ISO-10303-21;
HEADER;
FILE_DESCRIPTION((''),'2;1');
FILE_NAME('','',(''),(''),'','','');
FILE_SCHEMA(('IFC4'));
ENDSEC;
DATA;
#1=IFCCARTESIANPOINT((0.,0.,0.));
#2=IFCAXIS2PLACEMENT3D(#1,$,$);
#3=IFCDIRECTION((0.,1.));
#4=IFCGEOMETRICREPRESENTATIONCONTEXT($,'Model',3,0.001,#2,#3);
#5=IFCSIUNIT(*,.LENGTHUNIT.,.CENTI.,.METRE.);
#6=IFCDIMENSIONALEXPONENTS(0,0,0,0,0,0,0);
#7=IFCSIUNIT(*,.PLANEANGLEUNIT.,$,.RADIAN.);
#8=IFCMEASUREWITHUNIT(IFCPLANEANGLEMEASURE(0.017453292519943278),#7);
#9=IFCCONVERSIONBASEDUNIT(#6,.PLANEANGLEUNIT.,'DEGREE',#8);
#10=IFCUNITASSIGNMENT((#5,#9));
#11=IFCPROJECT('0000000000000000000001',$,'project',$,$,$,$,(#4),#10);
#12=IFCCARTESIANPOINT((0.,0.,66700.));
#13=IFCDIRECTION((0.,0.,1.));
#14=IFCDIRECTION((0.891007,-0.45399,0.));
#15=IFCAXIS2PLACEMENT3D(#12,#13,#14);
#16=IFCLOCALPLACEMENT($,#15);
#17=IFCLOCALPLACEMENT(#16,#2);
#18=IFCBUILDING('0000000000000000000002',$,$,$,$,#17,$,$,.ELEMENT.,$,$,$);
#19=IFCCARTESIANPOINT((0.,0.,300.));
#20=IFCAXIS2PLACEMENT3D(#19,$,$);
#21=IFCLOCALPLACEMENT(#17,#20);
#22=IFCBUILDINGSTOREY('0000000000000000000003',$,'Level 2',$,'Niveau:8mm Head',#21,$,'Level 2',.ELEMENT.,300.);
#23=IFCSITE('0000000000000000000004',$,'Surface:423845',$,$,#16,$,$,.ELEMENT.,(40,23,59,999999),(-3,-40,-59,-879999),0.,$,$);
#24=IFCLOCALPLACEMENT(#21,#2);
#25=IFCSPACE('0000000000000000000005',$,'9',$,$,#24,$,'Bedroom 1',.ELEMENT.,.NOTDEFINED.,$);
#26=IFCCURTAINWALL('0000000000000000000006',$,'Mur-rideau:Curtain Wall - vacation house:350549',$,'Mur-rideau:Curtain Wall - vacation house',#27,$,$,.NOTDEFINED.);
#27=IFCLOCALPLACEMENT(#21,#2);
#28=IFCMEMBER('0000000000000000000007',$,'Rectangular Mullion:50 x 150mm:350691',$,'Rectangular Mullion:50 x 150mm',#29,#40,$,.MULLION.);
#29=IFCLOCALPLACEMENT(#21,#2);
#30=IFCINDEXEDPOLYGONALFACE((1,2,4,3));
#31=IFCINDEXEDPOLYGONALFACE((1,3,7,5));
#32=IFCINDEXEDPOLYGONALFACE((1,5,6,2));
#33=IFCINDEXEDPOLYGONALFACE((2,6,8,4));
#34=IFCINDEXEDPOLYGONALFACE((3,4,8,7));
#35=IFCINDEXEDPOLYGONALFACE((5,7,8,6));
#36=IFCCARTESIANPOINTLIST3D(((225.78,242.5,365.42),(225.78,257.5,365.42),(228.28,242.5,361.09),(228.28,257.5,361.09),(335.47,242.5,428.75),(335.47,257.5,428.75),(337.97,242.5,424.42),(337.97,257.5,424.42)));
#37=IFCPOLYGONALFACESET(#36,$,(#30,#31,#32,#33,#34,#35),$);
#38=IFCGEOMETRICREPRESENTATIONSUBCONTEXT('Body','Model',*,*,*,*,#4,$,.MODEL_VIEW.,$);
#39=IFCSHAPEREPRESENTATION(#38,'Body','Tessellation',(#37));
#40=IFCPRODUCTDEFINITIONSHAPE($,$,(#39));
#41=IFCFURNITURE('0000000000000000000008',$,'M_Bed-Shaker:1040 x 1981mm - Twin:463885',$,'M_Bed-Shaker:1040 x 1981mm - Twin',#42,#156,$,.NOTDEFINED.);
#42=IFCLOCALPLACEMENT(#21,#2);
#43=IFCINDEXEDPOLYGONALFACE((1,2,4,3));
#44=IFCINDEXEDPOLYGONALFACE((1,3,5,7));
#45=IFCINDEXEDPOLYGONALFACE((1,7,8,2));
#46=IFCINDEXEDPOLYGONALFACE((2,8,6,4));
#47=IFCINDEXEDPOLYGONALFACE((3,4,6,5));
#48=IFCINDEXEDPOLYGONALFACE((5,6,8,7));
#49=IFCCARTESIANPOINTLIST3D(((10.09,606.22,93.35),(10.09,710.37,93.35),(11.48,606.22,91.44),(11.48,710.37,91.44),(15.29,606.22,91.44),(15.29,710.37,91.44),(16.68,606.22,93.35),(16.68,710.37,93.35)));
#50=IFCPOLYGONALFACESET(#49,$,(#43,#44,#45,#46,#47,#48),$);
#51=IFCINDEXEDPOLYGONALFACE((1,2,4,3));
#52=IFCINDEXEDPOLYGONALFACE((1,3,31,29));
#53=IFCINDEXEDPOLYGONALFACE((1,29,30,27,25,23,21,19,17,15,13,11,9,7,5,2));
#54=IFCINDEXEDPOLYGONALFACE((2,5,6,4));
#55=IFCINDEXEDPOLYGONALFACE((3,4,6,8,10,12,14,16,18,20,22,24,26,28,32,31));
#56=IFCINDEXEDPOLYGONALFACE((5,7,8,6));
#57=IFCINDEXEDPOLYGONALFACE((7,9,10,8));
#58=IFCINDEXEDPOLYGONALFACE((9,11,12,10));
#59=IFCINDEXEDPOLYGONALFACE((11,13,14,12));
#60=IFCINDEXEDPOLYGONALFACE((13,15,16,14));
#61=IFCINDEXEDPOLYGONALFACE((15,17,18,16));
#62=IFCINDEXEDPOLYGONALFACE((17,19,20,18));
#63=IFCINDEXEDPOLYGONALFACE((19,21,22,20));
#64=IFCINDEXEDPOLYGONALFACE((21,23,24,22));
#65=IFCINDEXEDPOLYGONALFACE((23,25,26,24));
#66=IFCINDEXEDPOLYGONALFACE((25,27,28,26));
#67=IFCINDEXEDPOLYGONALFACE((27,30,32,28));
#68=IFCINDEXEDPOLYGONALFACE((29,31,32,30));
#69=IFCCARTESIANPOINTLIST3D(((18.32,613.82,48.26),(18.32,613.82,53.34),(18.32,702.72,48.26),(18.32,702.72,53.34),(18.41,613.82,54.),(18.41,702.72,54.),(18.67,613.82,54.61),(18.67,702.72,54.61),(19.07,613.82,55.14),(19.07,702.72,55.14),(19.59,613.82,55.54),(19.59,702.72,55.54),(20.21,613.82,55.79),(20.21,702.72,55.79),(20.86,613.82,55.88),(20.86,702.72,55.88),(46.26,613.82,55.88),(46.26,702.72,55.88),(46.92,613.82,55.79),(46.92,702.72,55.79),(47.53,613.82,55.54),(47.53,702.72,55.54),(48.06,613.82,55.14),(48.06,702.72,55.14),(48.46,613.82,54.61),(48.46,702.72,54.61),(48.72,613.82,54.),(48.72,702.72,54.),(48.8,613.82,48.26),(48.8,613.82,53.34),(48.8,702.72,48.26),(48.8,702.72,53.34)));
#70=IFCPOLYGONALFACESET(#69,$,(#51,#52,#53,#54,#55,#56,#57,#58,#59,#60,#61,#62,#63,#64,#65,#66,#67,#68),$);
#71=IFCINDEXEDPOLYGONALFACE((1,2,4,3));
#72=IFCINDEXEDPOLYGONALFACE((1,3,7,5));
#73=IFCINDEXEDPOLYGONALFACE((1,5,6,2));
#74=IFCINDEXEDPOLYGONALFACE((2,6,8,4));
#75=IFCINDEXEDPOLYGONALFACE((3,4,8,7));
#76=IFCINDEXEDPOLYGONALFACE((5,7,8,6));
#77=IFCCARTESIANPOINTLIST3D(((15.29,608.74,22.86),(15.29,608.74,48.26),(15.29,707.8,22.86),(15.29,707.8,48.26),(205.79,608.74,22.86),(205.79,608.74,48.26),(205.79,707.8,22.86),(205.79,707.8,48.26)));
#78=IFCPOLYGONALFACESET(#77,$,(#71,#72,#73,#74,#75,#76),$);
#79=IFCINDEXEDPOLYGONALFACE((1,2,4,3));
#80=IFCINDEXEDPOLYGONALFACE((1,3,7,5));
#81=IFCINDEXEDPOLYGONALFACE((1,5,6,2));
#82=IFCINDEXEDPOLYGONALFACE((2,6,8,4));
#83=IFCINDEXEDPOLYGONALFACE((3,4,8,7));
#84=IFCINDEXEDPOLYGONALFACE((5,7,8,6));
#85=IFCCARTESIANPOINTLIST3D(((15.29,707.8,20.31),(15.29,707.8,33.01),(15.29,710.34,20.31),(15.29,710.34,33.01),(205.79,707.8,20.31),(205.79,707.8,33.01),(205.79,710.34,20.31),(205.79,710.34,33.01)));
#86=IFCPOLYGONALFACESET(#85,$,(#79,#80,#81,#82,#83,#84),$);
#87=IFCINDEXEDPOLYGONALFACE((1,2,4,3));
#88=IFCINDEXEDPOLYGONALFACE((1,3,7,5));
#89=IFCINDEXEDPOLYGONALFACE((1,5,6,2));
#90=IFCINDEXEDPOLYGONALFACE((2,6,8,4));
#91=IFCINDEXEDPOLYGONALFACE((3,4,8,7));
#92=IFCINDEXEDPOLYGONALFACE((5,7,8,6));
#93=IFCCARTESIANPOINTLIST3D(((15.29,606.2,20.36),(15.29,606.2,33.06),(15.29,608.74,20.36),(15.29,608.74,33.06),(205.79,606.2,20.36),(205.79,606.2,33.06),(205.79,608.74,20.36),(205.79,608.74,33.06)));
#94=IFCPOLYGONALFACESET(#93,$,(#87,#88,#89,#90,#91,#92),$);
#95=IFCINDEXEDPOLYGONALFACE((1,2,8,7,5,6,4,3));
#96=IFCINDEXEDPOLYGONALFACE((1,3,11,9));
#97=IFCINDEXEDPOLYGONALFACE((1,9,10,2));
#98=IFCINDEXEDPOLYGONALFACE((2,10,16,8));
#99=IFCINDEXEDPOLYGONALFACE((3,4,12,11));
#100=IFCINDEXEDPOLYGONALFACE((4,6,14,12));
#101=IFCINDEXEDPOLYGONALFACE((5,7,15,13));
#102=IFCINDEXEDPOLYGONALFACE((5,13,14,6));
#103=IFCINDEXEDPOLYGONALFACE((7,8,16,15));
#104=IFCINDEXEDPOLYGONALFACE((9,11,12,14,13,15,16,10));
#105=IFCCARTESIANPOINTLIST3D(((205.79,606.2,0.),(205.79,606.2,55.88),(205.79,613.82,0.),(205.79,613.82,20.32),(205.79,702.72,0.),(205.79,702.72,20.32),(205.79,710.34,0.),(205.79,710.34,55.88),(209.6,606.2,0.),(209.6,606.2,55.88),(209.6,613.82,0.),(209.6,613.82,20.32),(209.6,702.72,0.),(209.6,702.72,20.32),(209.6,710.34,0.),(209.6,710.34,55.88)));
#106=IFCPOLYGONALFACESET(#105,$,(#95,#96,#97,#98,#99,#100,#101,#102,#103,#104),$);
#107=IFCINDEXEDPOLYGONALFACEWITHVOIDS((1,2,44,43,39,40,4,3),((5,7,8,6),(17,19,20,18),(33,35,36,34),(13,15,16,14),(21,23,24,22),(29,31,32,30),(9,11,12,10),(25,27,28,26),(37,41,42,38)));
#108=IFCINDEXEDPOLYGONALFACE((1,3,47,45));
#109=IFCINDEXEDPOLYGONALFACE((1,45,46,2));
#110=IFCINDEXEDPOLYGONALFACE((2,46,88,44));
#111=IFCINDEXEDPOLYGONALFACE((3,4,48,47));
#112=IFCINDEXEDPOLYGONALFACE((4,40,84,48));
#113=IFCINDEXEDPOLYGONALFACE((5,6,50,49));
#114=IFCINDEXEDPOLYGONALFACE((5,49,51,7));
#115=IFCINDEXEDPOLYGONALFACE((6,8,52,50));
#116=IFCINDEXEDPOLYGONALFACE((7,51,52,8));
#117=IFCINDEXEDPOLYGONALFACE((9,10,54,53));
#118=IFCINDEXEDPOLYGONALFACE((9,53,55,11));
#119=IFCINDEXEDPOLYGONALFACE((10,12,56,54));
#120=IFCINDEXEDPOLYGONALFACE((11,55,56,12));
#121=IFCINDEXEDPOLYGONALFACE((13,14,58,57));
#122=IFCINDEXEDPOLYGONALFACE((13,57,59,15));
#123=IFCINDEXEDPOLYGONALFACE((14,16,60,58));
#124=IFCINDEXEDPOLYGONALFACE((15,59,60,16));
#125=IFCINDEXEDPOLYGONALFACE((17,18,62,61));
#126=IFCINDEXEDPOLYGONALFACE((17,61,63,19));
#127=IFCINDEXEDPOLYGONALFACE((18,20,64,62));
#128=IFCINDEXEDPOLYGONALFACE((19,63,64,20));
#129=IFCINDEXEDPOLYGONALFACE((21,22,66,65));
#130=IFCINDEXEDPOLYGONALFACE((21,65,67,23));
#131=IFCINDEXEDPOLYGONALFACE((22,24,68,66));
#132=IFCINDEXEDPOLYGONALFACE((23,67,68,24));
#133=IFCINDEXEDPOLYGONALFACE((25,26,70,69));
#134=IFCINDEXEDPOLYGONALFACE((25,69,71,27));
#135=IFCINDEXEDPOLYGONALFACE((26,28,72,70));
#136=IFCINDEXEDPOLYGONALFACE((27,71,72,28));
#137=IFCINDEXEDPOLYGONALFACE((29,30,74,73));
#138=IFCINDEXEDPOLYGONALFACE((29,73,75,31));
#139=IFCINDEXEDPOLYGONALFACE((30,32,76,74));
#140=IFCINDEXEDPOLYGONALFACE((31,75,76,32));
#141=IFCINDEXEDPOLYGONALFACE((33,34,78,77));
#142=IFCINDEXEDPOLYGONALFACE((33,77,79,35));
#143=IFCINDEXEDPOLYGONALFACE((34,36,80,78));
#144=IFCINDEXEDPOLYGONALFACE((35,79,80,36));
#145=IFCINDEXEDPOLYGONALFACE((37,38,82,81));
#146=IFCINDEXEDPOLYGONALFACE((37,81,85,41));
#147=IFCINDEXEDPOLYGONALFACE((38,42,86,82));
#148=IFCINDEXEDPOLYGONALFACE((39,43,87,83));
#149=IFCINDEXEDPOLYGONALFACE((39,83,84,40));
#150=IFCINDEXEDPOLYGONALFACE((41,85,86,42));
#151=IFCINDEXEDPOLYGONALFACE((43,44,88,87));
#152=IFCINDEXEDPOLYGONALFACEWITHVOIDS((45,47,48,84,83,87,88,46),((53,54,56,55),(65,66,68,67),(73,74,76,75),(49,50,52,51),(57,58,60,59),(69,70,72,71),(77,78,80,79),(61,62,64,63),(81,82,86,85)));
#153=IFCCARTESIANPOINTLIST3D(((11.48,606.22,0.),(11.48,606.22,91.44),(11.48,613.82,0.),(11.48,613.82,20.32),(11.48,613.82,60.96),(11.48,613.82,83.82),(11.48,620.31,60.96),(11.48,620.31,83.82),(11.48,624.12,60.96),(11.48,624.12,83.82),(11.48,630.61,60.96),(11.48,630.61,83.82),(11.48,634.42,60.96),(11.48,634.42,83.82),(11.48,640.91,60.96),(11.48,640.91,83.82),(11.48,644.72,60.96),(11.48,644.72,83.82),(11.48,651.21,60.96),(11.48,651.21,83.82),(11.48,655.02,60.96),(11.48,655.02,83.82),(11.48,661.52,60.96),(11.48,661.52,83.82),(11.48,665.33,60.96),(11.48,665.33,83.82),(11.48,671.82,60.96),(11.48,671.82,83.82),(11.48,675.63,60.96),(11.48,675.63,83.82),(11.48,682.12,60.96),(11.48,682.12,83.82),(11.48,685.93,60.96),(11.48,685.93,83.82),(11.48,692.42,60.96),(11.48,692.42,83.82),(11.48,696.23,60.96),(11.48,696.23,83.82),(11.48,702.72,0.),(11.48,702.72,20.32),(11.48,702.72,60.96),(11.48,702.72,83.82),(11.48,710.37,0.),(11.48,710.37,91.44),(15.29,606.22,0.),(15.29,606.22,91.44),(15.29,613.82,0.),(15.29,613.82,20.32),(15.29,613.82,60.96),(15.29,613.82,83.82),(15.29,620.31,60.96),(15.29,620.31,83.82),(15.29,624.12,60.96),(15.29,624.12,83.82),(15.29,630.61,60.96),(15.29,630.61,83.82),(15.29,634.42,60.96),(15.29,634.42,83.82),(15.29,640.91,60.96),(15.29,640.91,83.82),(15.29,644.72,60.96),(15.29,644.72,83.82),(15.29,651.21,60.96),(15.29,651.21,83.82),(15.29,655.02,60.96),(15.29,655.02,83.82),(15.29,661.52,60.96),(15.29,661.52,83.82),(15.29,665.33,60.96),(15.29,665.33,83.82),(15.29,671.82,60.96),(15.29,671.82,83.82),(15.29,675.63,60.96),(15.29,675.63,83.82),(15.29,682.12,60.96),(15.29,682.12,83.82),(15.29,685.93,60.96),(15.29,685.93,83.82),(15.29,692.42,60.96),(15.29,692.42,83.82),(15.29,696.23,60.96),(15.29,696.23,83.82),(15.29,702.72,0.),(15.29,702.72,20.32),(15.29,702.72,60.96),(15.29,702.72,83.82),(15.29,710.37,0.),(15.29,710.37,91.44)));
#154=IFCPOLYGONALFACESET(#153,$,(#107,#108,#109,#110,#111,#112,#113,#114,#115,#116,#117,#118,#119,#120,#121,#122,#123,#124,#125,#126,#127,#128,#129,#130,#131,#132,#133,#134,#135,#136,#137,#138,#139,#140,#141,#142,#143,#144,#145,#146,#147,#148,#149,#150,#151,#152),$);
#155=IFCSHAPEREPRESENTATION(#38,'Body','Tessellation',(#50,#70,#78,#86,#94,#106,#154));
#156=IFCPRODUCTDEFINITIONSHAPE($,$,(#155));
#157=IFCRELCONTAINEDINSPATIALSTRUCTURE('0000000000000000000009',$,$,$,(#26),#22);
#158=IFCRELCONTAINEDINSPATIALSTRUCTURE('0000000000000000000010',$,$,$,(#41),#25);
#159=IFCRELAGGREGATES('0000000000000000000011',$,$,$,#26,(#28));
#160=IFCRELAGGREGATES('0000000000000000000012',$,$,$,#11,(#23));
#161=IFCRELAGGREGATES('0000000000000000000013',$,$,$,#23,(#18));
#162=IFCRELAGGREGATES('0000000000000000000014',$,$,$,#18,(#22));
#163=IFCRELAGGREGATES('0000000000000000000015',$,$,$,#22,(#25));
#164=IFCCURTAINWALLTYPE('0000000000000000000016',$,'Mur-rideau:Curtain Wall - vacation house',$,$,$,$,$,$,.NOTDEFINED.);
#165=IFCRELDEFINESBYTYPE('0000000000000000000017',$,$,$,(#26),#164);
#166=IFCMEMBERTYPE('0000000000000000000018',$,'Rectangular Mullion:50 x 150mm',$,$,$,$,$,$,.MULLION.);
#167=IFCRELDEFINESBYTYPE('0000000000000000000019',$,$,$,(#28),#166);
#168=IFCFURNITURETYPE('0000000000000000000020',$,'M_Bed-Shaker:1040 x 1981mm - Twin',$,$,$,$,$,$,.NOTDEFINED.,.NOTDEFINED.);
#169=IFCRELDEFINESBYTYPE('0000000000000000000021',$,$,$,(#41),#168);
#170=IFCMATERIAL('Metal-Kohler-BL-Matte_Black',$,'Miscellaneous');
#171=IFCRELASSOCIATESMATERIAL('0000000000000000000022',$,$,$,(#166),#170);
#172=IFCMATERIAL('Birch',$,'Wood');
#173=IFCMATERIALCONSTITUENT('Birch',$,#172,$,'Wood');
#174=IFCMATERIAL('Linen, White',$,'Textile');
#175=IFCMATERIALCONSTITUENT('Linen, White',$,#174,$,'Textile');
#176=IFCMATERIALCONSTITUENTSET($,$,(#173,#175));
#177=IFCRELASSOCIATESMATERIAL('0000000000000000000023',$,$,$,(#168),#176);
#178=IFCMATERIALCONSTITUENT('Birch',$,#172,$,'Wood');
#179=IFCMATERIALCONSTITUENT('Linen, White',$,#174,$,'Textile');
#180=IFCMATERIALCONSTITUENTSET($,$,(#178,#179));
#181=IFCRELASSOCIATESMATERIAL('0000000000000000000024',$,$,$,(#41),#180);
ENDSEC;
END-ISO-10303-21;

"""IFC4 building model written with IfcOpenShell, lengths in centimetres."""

from ifc_helpers import new_model, entity, si_unit, converted_unit, direction, frame, frame_2d, origin, origin_2d_with_axis, place, context, subcontext, project, spatial, polyline, circle_curve, parameter, trimmed, segment, composite_curve, rectangle, outline, extrude, source, transform, mapped, material, constituent, constituent_set, material_profile, profile_set, type_object, type_shapes, element, aggregate, save


model = new_model("IFC4")

# Units and contexts
model_context = context("Model", 3, precision=0.001, world=origin(), true_north=direction((0.0, 1.0)))
body_context = subcontext(model_context, "Body", "Model", "MODEL_VIEW")
ifc_project = project(units=[si_unit("LENGTHUNIT", "METRE", prefix="CENTI"), converted_unit("PLANEANGLEUNIT", "DEGREE", entity("IfcPlaneAngleMeasure", 0.017453292519943278), si_unit("PLANEANGLEUNIT", "RADIAN"), dimensions=[0, 0, 0, 0, 0, 0, 0])], contexts=[model_context])

# Site, building, storey
site_placement = place(None, frame((0.0, 0.0, 66700.0), z_axis=(0.0, 0.0, 1.0), x_axis=(0.891007, -0.45399, 0.0)))
site = spatial("IfcSite", under=ifc_project, at=site_placement, Name="Surface:423845", CompositionType="ELEMENT", RefLatitude=(40, 23, 59, 999999), RefLongitude=(-3, -40, -59, -879999), RefElevation=0.0)
building_placement = place(site_placement, origin())
building = spatial("IfcBuilding", under=site, at=building_placement, CompositionType="ELEMENT")
storey_placement = place(building_placement, frame((0.0, 0.0, 300.0)))
storey = spatial("IfcBuildingStorey", under=building, at=storey_placement, Name="Level 2", ObjectType="Niveau:8mm Head", LongName="Level 2", CompositionType="ELEMENT", Elevation=300.0)

# Curtain wall, member
curtain_wall_type = type_object("IfcCurtainWallType", Name="Mur-rideau:Curtain Wall - vacation house", PredefinedType="NOTDEFINED")
curtain_wall_placement = place(storey_placement, frame((0.0, 0.0, -300.0)))
curtain_wall = element("IfcCurtainWall", 1, at=curtain_wall_placement, inside=storey, type_object=curtain_wall_type, Name="Mur-rideau:Curtain Wall - vacation house:350549", ObjectType="Mur-rideau:Curtain Wall - vacation house", PredefinedType="NOTDEFINED")
ifc_material_1 = material(Name="Metal-Kohler-BL-Matte_Black", Category="Miscellaneous")
ifc_material_profile = material_profile(ifc_material_1, rectangle(XDim=5.0, YDim=15.0, at=origin_2d_with_axis()), Name="50 x 150mm")
ifc_profile_set = profile_set([ifc_material_profile], Name="50 x 150mm")
member_type_1 = type_object("IfcMemberType", Name="Rectangular Mullion:50 x 150mm", PredefinedType="MULLION", material=ifc_profile_set)
shared_shape_1 = source(origin(), body_context, "Body", "SweptSolid", [
    extrude(rectangle(XDim=5.0, YDim=15.0, at=frame_2d((0.0, 0.0), x_axis=(1.0, 0.0))), frame((-2.5, 0.0, -126.66), z_axis=(0.0, 0.0, 1.0), x_axis=(-1.0, 0.0, 0.0)), (0.0, 0.0, 1.0), 126.66),
])
type_shapes(member_type_1, [shared_shape_1])
member_1_placement = place(curtain_wall_placement, frame((225.78, 250.0, 665.42), z_axis=(-0.866025, 0.0, -0.5), x_axis=(-0.5, 0.0, 0.866025)))
member_1 = element("IfcMember", 2, at=member_1_placement, type_object=member_type_1, Name="Rectangular Mullion:50 x 150mm:350691", ObjectType="Rectangular Mullion:50 x 150mm", PredefinedType="MULLION", context=body_context, shape_type="MappedRepresentation", body=[
    mapped(shared_shape_1, transform((0.0, 0.0, 0.0), scale=1.0)),
])
aggregate(curtain_wall, [member_1])

# Shared definitions
space_placement = place(storey_placement, origin())
space = spatial("IfcSpace", under=storey, at=space_placement, Name="9", LongName="Bedroom 1", CompositionType="ELEMENT", PredefinedType="NOTDEFINED")

# Furniture
ifc_material_2 = material(Name="Birch", Category="Wood")
ifc_constituent_1 = constituent(ifc_material_2, Name="Birch", Category="Wood")
ifc_material_3 = material(Name="Linen, White", Category="Textile")
ifc_constituent_2 = constituent(ifc_material_3, Name="Linen, White", Category="Textile")
ifc_constituent_set_1 = constituent_set(constituents=[ifc_constituent_1, ifc_constituent_2])
ifc_constituent_3 = constituent(ifc_material_2, Name="Birch", Category="Wood")
ifc_constituent_4 = constituent(ifc_material_3, Name="Linen, White", Category="Textile")
ifc_constituent_set_2 = constituent_set(constituents=[ifc_constituent_3, ifc_constituent_4])
furniture_type = type_object("IfcFurnitureType", Name="M_Bed-Shaker:1040 x 1981mm - Twin", AssemblyPlace="NOTDEFINED", PredefinedType="NOTDEFINED", material=ifc_constituent_set_2)
shared_shape_2 = source(origin(), body_context, "Body", "SweptSolid", [
    extrude(outline(polyline([(-1.91, -0.95), (1.9, -0.95), (3.29, 0.95), (-3.29, 0.95), (-1.91, -0.95)])), frame((-53.95, -1.9, 92.39), z_axis=(1.0, 0.0, 0.0), x_axis=(0.0, 1.0, 0.0)), (0.0, 0.0, 1.0), 104.15),
    extrude(outline(composite_curve([segment(polyline([(-15.24, -4.23), (15.24, -4.23)]), True, "CONTINUOUS"), segment(polyline([(15.24, -4.23), (15.24, 0.85)]), True, "CONTINUOUS"), segment(trimmed(circle_curve(frame_2d((12.7, 0.85), x_axis=(-1.0, 0.0)), 2.54), [parameter(180.0)], [parameter(270.0)], True, "PARAMETER"), True, "CONTINUOUS"), segment(polyline([(12.7, 3.39), (-12.7, 3.39)]), True, "CONTINUOUS"), segment(trimmed(circle_curve(frame_2d((-12.7, 0.85), x_axis=(-1.0, 0.0)), 2.54), [parameter(270.0)], [parameter(0.0)], True, "PARAMETER"), True, "CONTINUOUS"), segment(polyline([(-15.24, 0.85), (-15.24, -4.23)]), True, "CONTINUOUS")], self_intersect=False)), frame((-46.36, -22.08, 52.49), z_axis=(1.0, 0.0, 0.0), x_axis=(0.0, 1.0, 0.0)), (0.0, 0.0, 1.0), 88.9),
    extrude(rectangle(XDim=99.06, YDim=190.5, at=origin_2d_with_axis()), frame((-1.9, -99.06, 22.86), z_axis=(0.0, 0.0, 1.0), x_axis=(-1.0, 0.0, 0.0)), (0.0, 0.0, 1.0), 25.4),
    extrude(rectangle(XDim=2.54, YDim=190.5, at=frame_2d((0.0, 0.0), x_axis=(1.0, 0.0))), frame((48.89, -99.06, 20.31)), (0.0, 0.0, 1.0), 12.7),
    extrude(rectangle(XDim=2.54, YDim=190.5, at=frame_2d((0.0, 0.0), x_axis=(1.0, 0.0))), frame((-52.71, -99.06, 20.36)), (0.0, 0.0, 1.0), 12.7),
    extrude(outline(polyline([(44.45, -19.05), (52.07, -19.05), (52.07, 36.83), (-52.07, 36.83), (-52.07, -19.05), (-44.45, -19.05), (-44.45, 1.27), (44.45, 1.27), (44.45, -19.05)])), frame((-1.91, -198.12, 19.05), z_axis=(0.0, 1.0, 0.0), x_axis=(-1.0, 0.0, 0.0)), (0.0, 0.0, 1.0), 3.81),
    extrude(outline(polyline([(-63.5, -52.08), (27.94, -52.08), (27.94, -44.44), (7.62, -44.44), (7.62, 44.46), (27.94, 44.46), (27.94, 52.06), (-63.5, 52.06), (-63.5, -52.08)]), holes=[polyline([(-55.88, 37.97), (-55.88, 44.46), (-33.02, 44.46), (-33.02, 37.97), (-55.88, 37.97)]), polyline([(-55.88, 27.67), (-55.88, 34.16), (-33.02, 34.16), (-33.02, 27.67), (-55.88, 27.67)]), polyline([(-55.88, 17.37), (-55.88, 23.86), (-33.02, 23.86), (-33.02, 17.37), (-55.88, 17.37)]), polyline([(-55.88, 7.07), (-55.88, 13.56), (-33.02, 13.56), (-33.02, 7.07), (-55.88, 7.07)]), polyline([(-55.88, -13.53), (-55.88, -7.04), (-33.02, -7.04), (-33.02, -13.53), (-55.88, -13.53)]), polyline([(-55.88, -23.84), (-55.88, -17.34), (-33.02, -17.34), (-33.02, -23.84), (-55.88, -23.84)]), polyline([(-55.88, -34.14), (-55.88, -27.65), (-33.02, -27.65), (-33.02, -34.14), (-55.88, -34.14)]), polyline([(-55.88, -44.44), (-55.88, -37.95), (-33.02, -37.95), (-33.02, -44.44), (-55.88, -44.44)]), polyline([(-55.88, -3.23), (-55.88, 3.26), (-33.02, 3.26), (-33.02, -3.23), (-55.88, -3.23)])]), frame((-1.89, -3.81, 27.94), z_axis=(0.0, 1.0, 0.0), x_axis=(0.0, 0.0, -1.0)), (0.0, 0.0, 1.0), 3.81),
])
type_shapes(furniture_type, [shared_shape_2])
furniture_1_placement = place(space_placement, frame((11.48, 660.18, 0.0), z_axis=(0.0, 0.0, 1.0), x_axis=(0.0, 1.0, 0.0)))
element("IfcFurniture", 3, at=furniture_1_placement, inside=space, type_object=furniture_type, material=ifc_constituent_set_1, Name="M_Bed-Shaker:1040 x 1981mm - Twin:463885", ObjectType="M_Bed-Shaker:1040 x 1981mm - Twin", PredefinedType="NOTDEFINED", context=body_context, shape_type="MappedRepresentation", body=[
    mapped(shared_shape_2, transform((0.0, 0.0, 0.0), scale=1.0)),
])

save(model, "model.ifc")
